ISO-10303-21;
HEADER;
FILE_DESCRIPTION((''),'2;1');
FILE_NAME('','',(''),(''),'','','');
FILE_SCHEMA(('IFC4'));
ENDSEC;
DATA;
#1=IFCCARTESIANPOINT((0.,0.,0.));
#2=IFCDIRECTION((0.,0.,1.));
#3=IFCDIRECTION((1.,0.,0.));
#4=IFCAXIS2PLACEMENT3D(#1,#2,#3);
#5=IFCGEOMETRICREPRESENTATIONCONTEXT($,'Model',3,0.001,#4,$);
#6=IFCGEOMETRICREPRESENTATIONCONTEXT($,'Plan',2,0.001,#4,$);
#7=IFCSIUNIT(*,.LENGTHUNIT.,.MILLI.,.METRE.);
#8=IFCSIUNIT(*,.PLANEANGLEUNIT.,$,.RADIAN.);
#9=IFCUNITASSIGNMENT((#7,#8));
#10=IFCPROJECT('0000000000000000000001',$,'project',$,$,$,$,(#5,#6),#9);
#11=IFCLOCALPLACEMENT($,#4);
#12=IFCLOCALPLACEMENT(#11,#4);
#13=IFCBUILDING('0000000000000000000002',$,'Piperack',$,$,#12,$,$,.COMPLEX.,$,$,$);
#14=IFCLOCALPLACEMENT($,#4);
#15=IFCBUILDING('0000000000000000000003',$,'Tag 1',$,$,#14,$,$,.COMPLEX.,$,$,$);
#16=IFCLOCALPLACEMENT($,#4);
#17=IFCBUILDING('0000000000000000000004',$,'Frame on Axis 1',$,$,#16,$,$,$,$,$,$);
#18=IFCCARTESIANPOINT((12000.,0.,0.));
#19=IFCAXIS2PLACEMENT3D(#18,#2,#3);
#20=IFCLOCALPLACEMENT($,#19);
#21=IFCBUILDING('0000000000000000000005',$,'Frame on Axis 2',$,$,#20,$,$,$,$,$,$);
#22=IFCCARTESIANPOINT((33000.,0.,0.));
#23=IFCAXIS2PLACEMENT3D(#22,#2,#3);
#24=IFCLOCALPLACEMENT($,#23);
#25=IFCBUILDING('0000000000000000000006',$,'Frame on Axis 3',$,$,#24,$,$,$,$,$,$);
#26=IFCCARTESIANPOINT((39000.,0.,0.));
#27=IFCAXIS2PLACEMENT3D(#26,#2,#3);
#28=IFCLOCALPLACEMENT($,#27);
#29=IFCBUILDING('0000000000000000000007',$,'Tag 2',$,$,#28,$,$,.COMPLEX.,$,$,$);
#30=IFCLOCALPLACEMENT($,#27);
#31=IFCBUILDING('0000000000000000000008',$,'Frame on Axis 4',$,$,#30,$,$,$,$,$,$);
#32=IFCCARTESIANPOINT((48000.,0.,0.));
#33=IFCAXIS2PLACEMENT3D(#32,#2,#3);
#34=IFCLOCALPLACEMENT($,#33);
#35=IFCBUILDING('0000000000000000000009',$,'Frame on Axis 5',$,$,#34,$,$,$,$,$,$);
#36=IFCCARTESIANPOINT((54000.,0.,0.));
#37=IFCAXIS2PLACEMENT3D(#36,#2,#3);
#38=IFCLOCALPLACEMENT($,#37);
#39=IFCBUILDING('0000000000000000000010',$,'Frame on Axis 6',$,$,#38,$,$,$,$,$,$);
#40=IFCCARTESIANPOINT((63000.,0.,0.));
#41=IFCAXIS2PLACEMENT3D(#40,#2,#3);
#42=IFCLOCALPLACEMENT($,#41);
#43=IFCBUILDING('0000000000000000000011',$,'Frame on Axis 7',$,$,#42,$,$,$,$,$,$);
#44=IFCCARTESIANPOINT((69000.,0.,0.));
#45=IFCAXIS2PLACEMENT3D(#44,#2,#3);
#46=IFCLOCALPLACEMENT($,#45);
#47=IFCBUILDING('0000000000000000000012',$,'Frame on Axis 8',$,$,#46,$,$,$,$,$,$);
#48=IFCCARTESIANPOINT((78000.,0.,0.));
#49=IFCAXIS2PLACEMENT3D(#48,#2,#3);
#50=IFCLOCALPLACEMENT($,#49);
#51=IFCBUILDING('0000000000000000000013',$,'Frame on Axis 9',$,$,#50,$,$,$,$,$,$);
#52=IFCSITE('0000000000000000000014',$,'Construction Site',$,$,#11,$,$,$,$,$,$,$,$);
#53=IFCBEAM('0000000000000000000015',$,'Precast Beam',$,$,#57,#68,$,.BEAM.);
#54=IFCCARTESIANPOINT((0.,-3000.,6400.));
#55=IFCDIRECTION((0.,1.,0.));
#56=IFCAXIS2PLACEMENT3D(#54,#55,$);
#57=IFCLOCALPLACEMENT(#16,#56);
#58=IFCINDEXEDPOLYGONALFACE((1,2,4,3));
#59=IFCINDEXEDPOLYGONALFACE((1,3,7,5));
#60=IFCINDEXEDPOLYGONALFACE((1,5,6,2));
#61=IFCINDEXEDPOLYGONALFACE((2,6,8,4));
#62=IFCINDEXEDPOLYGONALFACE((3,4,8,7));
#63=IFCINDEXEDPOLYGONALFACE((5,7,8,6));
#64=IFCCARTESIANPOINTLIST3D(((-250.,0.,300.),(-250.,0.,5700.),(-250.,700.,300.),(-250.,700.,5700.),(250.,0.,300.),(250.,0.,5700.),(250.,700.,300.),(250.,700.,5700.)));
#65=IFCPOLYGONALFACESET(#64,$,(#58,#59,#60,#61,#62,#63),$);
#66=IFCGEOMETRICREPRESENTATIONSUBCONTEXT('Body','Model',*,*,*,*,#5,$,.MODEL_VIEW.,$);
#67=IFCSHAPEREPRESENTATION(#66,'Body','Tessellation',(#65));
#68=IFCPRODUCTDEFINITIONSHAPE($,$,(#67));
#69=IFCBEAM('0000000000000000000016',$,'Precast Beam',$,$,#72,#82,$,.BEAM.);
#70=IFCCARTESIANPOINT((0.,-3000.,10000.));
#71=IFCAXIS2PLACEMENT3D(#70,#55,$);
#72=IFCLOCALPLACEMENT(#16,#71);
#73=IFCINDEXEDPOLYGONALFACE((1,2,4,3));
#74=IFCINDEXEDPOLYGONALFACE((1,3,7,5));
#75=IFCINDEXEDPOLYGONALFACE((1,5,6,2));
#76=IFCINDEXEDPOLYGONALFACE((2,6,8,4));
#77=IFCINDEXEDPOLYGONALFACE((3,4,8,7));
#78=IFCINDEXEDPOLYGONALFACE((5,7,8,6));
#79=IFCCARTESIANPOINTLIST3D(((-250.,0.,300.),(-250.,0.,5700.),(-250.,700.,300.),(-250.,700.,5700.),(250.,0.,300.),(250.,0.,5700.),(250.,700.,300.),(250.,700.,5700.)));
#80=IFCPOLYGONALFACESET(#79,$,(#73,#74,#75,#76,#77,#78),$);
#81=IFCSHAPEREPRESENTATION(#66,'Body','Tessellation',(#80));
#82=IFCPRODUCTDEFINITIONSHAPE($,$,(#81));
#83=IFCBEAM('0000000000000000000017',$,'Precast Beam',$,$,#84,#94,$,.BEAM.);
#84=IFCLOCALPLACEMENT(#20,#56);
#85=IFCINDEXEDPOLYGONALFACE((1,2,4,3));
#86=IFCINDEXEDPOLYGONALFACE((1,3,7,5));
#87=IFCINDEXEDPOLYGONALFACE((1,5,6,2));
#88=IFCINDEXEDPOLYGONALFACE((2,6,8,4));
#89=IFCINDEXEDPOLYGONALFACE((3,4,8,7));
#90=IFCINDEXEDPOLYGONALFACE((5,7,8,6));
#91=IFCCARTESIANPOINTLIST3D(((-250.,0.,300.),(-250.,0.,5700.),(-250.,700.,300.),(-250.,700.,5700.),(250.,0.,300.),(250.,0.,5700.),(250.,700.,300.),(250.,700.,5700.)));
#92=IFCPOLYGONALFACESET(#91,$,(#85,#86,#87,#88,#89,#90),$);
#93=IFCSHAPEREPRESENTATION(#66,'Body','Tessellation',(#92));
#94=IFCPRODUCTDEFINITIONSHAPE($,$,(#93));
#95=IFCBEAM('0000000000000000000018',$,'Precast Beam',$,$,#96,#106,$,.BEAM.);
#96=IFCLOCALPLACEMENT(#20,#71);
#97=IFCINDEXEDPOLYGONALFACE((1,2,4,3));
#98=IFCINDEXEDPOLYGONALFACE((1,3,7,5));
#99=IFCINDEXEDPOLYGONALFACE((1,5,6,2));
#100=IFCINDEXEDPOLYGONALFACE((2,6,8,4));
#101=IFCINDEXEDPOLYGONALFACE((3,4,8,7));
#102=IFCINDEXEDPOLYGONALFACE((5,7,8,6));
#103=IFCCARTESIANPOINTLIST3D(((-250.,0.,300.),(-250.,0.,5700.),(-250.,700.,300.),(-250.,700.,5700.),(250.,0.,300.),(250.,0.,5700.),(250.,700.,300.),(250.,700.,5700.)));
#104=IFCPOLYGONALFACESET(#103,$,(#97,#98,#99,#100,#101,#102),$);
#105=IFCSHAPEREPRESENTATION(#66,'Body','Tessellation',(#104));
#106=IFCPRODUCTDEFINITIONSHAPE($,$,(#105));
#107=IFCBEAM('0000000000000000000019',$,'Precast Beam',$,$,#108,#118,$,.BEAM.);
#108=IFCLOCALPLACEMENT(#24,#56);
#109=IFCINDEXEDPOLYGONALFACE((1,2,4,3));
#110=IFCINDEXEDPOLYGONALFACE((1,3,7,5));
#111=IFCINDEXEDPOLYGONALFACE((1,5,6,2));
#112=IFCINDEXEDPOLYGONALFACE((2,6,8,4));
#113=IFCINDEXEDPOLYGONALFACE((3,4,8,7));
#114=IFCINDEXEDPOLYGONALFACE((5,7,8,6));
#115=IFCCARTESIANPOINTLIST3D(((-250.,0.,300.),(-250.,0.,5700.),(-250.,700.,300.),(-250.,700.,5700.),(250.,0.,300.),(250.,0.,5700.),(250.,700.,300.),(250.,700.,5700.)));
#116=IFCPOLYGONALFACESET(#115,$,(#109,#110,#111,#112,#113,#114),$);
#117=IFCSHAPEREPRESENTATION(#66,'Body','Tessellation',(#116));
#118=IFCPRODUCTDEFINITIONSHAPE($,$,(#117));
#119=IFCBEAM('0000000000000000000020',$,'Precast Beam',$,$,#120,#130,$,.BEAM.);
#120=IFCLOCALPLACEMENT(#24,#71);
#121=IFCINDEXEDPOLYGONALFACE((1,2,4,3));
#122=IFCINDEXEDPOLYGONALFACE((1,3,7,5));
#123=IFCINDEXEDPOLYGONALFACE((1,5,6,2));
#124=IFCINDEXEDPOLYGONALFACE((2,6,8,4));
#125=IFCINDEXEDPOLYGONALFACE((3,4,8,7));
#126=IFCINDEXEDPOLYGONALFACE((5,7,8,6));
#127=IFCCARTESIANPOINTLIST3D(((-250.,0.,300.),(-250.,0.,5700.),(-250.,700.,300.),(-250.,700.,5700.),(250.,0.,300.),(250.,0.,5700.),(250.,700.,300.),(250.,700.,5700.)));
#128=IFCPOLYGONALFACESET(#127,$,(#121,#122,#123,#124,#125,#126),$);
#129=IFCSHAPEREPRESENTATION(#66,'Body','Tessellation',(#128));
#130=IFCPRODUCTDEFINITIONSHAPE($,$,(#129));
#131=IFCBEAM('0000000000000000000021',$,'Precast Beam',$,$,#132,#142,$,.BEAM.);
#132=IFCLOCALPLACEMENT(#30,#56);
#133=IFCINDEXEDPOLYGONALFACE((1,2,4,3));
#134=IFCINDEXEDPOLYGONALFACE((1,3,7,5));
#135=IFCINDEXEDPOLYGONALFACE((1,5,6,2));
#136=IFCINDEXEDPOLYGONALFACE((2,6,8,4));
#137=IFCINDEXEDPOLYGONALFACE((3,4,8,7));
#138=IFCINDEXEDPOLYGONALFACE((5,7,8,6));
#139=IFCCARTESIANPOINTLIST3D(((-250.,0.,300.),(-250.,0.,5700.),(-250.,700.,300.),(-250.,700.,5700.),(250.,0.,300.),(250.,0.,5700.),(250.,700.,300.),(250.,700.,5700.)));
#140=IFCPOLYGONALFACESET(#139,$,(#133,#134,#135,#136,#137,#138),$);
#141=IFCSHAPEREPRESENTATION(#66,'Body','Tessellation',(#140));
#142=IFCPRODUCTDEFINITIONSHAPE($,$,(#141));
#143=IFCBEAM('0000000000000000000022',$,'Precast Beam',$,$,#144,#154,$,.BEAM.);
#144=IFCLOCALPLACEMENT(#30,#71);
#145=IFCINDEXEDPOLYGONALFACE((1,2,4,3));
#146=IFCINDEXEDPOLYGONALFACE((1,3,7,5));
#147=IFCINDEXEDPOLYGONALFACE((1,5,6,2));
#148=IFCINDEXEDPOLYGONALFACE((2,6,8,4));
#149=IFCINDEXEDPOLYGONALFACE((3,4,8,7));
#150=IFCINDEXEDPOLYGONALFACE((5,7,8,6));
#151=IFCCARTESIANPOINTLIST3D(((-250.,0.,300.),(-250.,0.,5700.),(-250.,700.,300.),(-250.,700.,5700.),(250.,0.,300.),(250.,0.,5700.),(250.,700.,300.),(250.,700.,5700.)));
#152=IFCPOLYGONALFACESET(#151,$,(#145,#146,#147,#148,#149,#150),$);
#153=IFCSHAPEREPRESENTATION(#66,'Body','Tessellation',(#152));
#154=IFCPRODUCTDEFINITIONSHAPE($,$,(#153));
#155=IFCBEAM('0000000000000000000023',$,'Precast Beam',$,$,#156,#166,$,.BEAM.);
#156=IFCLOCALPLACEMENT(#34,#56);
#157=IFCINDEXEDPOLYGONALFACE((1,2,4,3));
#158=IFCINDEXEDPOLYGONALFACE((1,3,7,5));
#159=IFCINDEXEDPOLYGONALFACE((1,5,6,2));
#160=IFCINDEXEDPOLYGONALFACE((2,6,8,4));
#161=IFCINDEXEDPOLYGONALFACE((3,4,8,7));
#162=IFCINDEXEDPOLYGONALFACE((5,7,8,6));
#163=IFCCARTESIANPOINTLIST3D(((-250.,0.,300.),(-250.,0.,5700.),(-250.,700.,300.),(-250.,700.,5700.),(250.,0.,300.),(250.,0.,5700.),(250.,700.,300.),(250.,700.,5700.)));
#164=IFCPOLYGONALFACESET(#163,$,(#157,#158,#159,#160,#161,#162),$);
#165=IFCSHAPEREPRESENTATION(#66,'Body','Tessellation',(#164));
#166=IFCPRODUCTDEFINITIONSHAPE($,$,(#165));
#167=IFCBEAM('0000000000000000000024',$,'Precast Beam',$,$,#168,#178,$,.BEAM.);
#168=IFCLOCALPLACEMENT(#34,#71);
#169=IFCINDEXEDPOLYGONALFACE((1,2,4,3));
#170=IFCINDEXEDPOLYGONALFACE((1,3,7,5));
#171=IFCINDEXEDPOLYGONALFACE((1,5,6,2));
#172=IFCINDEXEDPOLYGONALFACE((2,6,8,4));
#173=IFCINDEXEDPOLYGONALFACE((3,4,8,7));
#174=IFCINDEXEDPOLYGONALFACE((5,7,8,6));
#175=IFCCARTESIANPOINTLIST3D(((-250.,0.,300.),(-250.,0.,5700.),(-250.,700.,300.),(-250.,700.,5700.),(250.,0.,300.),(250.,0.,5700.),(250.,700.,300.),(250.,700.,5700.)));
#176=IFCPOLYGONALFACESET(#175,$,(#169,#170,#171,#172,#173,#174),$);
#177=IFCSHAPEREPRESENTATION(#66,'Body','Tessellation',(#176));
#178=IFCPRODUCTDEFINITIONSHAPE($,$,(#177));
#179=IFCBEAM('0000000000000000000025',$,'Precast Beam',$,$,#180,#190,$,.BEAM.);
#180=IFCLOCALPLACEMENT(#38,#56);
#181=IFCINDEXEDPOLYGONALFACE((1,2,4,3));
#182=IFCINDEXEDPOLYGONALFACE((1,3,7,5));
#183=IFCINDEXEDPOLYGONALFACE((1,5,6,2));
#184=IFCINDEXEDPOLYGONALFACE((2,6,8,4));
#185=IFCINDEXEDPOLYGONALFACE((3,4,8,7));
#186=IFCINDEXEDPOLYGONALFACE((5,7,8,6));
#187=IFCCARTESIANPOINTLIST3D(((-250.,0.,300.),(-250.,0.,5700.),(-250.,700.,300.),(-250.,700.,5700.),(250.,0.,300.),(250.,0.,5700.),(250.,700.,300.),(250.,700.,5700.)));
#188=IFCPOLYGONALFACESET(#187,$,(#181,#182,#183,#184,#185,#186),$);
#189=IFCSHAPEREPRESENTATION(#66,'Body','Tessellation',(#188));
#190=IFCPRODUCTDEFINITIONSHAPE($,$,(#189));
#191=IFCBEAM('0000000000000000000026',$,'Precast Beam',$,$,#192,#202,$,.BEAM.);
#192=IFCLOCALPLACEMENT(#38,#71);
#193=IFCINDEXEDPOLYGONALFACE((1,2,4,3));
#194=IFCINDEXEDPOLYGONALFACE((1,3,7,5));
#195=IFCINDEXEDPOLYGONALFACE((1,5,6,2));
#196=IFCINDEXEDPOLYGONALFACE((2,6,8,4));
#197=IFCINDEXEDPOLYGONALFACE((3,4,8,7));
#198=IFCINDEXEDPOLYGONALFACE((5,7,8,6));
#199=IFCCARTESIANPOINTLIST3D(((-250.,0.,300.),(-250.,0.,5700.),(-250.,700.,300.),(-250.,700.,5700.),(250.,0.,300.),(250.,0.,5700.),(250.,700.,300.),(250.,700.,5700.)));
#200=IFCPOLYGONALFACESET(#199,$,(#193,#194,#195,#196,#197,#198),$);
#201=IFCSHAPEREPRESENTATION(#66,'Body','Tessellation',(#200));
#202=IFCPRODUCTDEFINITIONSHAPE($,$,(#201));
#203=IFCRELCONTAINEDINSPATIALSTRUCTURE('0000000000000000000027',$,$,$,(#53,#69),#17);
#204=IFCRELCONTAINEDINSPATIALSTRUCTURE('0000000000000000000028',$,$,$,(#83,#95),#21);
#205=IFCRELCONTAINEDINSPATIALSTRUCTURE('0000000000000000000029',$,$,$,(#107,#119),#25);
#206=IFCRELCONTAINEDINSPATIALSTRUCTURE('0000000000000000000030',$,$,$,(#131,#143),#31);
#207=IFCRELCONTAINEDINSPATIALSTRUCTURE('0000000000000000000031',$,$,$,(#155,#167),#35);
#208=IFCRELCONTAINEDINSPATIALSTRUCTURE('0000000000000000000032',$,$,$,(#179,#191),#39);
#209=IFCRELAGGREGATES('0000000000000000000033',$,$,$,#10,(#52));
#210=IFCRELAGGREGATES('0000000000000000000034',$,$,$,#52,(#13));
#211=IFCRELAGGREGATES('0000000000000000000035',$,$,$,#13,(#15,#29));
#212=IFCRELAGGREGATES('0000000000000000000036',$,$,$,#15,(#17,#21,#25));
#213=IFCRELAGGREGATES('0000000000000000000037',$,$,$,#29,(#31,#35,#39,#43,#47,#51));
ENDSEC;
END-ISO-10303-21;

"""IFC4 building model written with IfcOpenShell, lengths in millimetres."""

from ifc_helpers import new_model, si_unit, frame, origin_with_axes, place, context, subcontext, project, spatial, rectangle, extrude, element, save


model = new_model("IFC4")

# Units and contexts
model_context = context("Model", 3, precision=0.001, world=origin_with_axes())
plan_context = context("Plan", 2, precision=0.001, world=origin_with_axes())
body_context = subcontext(model_context, "Body", "Model", "MODEL_VIEW")
ifc_project = project(units=[si_unit("LENGTHUNIT", "METRE", prefix="MILLI"), si_unit("PLANEANGLEUNIT", "RADIAN")], contexts=[model_context, plan_context])

# Site, buildings
site_placement = place(None, origin_with_axes())
site = spatial("IfcSite", under=ifc_project, at=site_placement, Name="Construction Site")
building_1_placement = place(site_placement, origin_with_axes())
building_1 = spatial("IfcBuilding", under=site, at=building_1_placement, Name="Piperack", CompositionType="COMPLEX")
building_2_placement = place(None, origin_with_axes())
building_2 = spatial("IfcBuilding", under=building_1, at=building_2_placement, Name="Tag 1", CompositionType="COMPLEX")
building_3_placement = place(None, origin_with_axes())
building_3 = spatial("IfcBuilding", under=building_2, at=building_3_placement, Name="Frame on Axis 1")

# Shared definitions
building_4_placement = place(None, frame((12000.0, 0.0, 0.0), z_axis=(0.0, 0.0, 1.0), x_axis=(1.0, 0.0, 0.0)))
building_4 = spatial("IfcBuilding", under=building_2, at=building_4_placement, Name="Frame on Axis 2")

# Shared definitions
building_5_placement = place(None, frame((33000.0, 0.0, 0.0), z_axis=(0.0, 0.0, 1.0), x_axis=(1.0, 0.0, 0.0)))
building_5 = spatial("IfcBuilding", under=building_2, at=building_5_placement, Name="Frame on Axis 3")

# Shared definitions
building_6_placement = place(None, frame((39000.0, 0.0, 0.0), z_axis=(0.0, 0.0, 1.0), x_axis=(1.0, 0.0, 0.0)))
building_6 = spatial("IfcBuilding", under=building_1, at=building_6_placement, Name="Tag 2", CompositionType="COMPLEX")
building_7_placement = place(None, frame((39000.0, 0.0, 0.0), z_axis=(0.0, 0.0, 1.0), x_axis=(1.0, 0.0, 0.0)))
building_7 = spatial("IfcBuilding", under=building_6, at=building_7_placement, Name="Frame on Axis 4")

# Shared definitions
building_8_placement = place(None, frame((48000.0, 0.0, 0.0), z_axis=(0.0, 0.0, 1.0), x_axis=(1.0, 0.0, 0.0)))
building_8 = spatial("IfcBuilding", under=building_6, at=building_8_placement, Name="Frame on Axis 5")

# Shared definitions
building_9_placement = place(None, frame((54000.0, 0.0, 0.0), z_axis=(0.0, 0.0, 1.0), x_axis=(1.0, 0.0, 0.0)))
building_9 = spatial("IfcBuilding", under=building_6, at=building_9_placement, Name="Frame on Axis 6")

# Shared definitions
building_10_placement = place(None, frame((63000.0, 0.0, 0.0), z_axis=(0.0, 0.0, 1.0), x_axis=(1.0, 0.0, 0.0)))
building_10 = spatial("IfcBuilding", under=building_6, at=building_10_placement, Name="Frame on Axis 7")

# Shared definitions
building_11_placement = place(None, frame((69000.0, 0.0, 0.0), z_axis=(0.0, 0.0, 1.0), x_axis=(1.0, 0.0, 0.0)))
building_11 = spatial("IfcBuilding", under=building_6, at=building_11_placement, Name="Frame on Axis 8")

# Shared definitions
building_12_placement = place(None, frame((78000.0, 0.0, 0.0), z_axis=(0.0, 0.0, 1.0), x_axis=(1.0, 0.0, 0.0)))
building_12 = spatial("IfcBuilding", under=building_6, at=building_12_placement, Name="Frame on Axis 9")

# Beams
for number, where, z_axis, name in (
    (1, (0.0, -3000.0, 6400.0), (0.0, 1.0, 0.0), "Precast Beam"),
    (2, (0.0, -3000.0, 10000.0), (0.0, 1.0, 0.0), "Precast Beam"),
):
    element("IfcBeam", number, at=place(building_3_placement, frame(where, z_axis=z_axis)), inside=building_3, Name=name, PredefinedType="BEAM", context=body_context, shape_type="SweptSolid", body=[
        extrude(rectangle(XDim=500.0, YDim=700.0), frame((0.0, 350.0, 300.0)), (0.0, 0.0, 1.0), 5400.0),
    ])
for number, where, z_axis, name in (
    (3, (0.0, -3000.0, 6400.0), (0.0, 1.0, 0.0), "Precast Beam"),
    (4, (0.0, -3000.0, 10000.0), (0.0, 1.0, 0.0), "Precast Beam"),
):
    element("IfcBeam", number, at=place(building_4_placement, frame(where, z_axis=z_axis)), inside=building_4, Name=name, PredefinedType="BEAM", context=body_context, shape_type="SweptSolid", body=[
        extrude(rectangle(XDim=500.0, YDim=700.0), frame((0.0, 350.0, 300.0)), (0.0, 0.0, 1.0), 5400.0),
    ])
for number, where, z_axis, name in (
    (5, (0.0, -3000.0, 6400.0), (0.0, 1.0, 0.0), "Precast Beam"),
    (6, (0.0, -3000.0, 10000.0), (0.0, 1.0, 0.0), "Precast Beam"),
):
    element("IfcBeam", number, at=place(building_5_placement, frame(where, z_axis=z_axis)), inside=building_5, Name=name, PredefinedType="BEAM", context=body_context, shape_type="SweptSolid", body=[
        extrude(rectangle(XDim=500.0, YDim=700.0), frame((0.0, 350.0, 300.0)), (0.0, 0.0, 1.0), 5400.0),
    ])
for number, where, z_axis, name in (
    (7, (0.0, -3000.0, 6400.0), (0.0, 1.0, 0.0), "Precast Beam"),
    (8, (0.0, -3000.0, 10000.0), (0.0, 1.0, 0.0), "Precast Beam"),
):
    element("IfcBeam", number, at=place(building_7_placement, frame(where, z_axis=z_axis)), inside=building_7, Name=name, PredefinedType="BEAM", context=body_context, shape_type="SweptSolid", body=[
        extrude(rectangle(XDim=500.0, YDim=700.0), frame((0.0, 350.0, 300.0)), (0.0, 0.0, 1.0), 5400.0),
    ])
for number, where, z_axis, name in (
    (9, (0.0, -3000.0, 6400.0), (0.0, 1.0, 0.0), "Precast Beam"),
    (10, (0.0, -3000.0, 10000.0), (0.0, 1.0, 0.0), "Precast Beam"),
):
    element("IfcBeam", number, at=place(building_8_placement, frame(where, z_axis=z_axis)), inside=building_8, Name=name, PredefinedType="BEAM", context=body_context, shape_type="SweptSolid", body=[
        extrude(rectangle(XDim=500.0, YDim=700.0), frame((0.0, 350.0, 300.0)), (0.0, 0.0, 1.0), 5400.0),
    ])
for number, where, z_axis, name in (
    (11, (0.0, -3000.0, 6400.0), (0.0, 1.0, 0.0), "Precast Beam"),
    (12, (0.0, -3000.0, 10000.0), (0.0, 1.0, 0.0), "Precast Beam"),
):
    element("IfcBeam", number, at=place(building_9_placement, frame(where, z_axis=z_axis)), inside=building_9, Name=name, PredefinedType="BEAM", context=body_context, shape_type="SweptSolid", body=[
        extrude(rectangle(XDim=500.0, YDim=700.0), frame((0.0, 350.0, 300.0)), (0.0, 0.0, 1.0), 5400.0),
    ])

save(model, "model.ifc")
